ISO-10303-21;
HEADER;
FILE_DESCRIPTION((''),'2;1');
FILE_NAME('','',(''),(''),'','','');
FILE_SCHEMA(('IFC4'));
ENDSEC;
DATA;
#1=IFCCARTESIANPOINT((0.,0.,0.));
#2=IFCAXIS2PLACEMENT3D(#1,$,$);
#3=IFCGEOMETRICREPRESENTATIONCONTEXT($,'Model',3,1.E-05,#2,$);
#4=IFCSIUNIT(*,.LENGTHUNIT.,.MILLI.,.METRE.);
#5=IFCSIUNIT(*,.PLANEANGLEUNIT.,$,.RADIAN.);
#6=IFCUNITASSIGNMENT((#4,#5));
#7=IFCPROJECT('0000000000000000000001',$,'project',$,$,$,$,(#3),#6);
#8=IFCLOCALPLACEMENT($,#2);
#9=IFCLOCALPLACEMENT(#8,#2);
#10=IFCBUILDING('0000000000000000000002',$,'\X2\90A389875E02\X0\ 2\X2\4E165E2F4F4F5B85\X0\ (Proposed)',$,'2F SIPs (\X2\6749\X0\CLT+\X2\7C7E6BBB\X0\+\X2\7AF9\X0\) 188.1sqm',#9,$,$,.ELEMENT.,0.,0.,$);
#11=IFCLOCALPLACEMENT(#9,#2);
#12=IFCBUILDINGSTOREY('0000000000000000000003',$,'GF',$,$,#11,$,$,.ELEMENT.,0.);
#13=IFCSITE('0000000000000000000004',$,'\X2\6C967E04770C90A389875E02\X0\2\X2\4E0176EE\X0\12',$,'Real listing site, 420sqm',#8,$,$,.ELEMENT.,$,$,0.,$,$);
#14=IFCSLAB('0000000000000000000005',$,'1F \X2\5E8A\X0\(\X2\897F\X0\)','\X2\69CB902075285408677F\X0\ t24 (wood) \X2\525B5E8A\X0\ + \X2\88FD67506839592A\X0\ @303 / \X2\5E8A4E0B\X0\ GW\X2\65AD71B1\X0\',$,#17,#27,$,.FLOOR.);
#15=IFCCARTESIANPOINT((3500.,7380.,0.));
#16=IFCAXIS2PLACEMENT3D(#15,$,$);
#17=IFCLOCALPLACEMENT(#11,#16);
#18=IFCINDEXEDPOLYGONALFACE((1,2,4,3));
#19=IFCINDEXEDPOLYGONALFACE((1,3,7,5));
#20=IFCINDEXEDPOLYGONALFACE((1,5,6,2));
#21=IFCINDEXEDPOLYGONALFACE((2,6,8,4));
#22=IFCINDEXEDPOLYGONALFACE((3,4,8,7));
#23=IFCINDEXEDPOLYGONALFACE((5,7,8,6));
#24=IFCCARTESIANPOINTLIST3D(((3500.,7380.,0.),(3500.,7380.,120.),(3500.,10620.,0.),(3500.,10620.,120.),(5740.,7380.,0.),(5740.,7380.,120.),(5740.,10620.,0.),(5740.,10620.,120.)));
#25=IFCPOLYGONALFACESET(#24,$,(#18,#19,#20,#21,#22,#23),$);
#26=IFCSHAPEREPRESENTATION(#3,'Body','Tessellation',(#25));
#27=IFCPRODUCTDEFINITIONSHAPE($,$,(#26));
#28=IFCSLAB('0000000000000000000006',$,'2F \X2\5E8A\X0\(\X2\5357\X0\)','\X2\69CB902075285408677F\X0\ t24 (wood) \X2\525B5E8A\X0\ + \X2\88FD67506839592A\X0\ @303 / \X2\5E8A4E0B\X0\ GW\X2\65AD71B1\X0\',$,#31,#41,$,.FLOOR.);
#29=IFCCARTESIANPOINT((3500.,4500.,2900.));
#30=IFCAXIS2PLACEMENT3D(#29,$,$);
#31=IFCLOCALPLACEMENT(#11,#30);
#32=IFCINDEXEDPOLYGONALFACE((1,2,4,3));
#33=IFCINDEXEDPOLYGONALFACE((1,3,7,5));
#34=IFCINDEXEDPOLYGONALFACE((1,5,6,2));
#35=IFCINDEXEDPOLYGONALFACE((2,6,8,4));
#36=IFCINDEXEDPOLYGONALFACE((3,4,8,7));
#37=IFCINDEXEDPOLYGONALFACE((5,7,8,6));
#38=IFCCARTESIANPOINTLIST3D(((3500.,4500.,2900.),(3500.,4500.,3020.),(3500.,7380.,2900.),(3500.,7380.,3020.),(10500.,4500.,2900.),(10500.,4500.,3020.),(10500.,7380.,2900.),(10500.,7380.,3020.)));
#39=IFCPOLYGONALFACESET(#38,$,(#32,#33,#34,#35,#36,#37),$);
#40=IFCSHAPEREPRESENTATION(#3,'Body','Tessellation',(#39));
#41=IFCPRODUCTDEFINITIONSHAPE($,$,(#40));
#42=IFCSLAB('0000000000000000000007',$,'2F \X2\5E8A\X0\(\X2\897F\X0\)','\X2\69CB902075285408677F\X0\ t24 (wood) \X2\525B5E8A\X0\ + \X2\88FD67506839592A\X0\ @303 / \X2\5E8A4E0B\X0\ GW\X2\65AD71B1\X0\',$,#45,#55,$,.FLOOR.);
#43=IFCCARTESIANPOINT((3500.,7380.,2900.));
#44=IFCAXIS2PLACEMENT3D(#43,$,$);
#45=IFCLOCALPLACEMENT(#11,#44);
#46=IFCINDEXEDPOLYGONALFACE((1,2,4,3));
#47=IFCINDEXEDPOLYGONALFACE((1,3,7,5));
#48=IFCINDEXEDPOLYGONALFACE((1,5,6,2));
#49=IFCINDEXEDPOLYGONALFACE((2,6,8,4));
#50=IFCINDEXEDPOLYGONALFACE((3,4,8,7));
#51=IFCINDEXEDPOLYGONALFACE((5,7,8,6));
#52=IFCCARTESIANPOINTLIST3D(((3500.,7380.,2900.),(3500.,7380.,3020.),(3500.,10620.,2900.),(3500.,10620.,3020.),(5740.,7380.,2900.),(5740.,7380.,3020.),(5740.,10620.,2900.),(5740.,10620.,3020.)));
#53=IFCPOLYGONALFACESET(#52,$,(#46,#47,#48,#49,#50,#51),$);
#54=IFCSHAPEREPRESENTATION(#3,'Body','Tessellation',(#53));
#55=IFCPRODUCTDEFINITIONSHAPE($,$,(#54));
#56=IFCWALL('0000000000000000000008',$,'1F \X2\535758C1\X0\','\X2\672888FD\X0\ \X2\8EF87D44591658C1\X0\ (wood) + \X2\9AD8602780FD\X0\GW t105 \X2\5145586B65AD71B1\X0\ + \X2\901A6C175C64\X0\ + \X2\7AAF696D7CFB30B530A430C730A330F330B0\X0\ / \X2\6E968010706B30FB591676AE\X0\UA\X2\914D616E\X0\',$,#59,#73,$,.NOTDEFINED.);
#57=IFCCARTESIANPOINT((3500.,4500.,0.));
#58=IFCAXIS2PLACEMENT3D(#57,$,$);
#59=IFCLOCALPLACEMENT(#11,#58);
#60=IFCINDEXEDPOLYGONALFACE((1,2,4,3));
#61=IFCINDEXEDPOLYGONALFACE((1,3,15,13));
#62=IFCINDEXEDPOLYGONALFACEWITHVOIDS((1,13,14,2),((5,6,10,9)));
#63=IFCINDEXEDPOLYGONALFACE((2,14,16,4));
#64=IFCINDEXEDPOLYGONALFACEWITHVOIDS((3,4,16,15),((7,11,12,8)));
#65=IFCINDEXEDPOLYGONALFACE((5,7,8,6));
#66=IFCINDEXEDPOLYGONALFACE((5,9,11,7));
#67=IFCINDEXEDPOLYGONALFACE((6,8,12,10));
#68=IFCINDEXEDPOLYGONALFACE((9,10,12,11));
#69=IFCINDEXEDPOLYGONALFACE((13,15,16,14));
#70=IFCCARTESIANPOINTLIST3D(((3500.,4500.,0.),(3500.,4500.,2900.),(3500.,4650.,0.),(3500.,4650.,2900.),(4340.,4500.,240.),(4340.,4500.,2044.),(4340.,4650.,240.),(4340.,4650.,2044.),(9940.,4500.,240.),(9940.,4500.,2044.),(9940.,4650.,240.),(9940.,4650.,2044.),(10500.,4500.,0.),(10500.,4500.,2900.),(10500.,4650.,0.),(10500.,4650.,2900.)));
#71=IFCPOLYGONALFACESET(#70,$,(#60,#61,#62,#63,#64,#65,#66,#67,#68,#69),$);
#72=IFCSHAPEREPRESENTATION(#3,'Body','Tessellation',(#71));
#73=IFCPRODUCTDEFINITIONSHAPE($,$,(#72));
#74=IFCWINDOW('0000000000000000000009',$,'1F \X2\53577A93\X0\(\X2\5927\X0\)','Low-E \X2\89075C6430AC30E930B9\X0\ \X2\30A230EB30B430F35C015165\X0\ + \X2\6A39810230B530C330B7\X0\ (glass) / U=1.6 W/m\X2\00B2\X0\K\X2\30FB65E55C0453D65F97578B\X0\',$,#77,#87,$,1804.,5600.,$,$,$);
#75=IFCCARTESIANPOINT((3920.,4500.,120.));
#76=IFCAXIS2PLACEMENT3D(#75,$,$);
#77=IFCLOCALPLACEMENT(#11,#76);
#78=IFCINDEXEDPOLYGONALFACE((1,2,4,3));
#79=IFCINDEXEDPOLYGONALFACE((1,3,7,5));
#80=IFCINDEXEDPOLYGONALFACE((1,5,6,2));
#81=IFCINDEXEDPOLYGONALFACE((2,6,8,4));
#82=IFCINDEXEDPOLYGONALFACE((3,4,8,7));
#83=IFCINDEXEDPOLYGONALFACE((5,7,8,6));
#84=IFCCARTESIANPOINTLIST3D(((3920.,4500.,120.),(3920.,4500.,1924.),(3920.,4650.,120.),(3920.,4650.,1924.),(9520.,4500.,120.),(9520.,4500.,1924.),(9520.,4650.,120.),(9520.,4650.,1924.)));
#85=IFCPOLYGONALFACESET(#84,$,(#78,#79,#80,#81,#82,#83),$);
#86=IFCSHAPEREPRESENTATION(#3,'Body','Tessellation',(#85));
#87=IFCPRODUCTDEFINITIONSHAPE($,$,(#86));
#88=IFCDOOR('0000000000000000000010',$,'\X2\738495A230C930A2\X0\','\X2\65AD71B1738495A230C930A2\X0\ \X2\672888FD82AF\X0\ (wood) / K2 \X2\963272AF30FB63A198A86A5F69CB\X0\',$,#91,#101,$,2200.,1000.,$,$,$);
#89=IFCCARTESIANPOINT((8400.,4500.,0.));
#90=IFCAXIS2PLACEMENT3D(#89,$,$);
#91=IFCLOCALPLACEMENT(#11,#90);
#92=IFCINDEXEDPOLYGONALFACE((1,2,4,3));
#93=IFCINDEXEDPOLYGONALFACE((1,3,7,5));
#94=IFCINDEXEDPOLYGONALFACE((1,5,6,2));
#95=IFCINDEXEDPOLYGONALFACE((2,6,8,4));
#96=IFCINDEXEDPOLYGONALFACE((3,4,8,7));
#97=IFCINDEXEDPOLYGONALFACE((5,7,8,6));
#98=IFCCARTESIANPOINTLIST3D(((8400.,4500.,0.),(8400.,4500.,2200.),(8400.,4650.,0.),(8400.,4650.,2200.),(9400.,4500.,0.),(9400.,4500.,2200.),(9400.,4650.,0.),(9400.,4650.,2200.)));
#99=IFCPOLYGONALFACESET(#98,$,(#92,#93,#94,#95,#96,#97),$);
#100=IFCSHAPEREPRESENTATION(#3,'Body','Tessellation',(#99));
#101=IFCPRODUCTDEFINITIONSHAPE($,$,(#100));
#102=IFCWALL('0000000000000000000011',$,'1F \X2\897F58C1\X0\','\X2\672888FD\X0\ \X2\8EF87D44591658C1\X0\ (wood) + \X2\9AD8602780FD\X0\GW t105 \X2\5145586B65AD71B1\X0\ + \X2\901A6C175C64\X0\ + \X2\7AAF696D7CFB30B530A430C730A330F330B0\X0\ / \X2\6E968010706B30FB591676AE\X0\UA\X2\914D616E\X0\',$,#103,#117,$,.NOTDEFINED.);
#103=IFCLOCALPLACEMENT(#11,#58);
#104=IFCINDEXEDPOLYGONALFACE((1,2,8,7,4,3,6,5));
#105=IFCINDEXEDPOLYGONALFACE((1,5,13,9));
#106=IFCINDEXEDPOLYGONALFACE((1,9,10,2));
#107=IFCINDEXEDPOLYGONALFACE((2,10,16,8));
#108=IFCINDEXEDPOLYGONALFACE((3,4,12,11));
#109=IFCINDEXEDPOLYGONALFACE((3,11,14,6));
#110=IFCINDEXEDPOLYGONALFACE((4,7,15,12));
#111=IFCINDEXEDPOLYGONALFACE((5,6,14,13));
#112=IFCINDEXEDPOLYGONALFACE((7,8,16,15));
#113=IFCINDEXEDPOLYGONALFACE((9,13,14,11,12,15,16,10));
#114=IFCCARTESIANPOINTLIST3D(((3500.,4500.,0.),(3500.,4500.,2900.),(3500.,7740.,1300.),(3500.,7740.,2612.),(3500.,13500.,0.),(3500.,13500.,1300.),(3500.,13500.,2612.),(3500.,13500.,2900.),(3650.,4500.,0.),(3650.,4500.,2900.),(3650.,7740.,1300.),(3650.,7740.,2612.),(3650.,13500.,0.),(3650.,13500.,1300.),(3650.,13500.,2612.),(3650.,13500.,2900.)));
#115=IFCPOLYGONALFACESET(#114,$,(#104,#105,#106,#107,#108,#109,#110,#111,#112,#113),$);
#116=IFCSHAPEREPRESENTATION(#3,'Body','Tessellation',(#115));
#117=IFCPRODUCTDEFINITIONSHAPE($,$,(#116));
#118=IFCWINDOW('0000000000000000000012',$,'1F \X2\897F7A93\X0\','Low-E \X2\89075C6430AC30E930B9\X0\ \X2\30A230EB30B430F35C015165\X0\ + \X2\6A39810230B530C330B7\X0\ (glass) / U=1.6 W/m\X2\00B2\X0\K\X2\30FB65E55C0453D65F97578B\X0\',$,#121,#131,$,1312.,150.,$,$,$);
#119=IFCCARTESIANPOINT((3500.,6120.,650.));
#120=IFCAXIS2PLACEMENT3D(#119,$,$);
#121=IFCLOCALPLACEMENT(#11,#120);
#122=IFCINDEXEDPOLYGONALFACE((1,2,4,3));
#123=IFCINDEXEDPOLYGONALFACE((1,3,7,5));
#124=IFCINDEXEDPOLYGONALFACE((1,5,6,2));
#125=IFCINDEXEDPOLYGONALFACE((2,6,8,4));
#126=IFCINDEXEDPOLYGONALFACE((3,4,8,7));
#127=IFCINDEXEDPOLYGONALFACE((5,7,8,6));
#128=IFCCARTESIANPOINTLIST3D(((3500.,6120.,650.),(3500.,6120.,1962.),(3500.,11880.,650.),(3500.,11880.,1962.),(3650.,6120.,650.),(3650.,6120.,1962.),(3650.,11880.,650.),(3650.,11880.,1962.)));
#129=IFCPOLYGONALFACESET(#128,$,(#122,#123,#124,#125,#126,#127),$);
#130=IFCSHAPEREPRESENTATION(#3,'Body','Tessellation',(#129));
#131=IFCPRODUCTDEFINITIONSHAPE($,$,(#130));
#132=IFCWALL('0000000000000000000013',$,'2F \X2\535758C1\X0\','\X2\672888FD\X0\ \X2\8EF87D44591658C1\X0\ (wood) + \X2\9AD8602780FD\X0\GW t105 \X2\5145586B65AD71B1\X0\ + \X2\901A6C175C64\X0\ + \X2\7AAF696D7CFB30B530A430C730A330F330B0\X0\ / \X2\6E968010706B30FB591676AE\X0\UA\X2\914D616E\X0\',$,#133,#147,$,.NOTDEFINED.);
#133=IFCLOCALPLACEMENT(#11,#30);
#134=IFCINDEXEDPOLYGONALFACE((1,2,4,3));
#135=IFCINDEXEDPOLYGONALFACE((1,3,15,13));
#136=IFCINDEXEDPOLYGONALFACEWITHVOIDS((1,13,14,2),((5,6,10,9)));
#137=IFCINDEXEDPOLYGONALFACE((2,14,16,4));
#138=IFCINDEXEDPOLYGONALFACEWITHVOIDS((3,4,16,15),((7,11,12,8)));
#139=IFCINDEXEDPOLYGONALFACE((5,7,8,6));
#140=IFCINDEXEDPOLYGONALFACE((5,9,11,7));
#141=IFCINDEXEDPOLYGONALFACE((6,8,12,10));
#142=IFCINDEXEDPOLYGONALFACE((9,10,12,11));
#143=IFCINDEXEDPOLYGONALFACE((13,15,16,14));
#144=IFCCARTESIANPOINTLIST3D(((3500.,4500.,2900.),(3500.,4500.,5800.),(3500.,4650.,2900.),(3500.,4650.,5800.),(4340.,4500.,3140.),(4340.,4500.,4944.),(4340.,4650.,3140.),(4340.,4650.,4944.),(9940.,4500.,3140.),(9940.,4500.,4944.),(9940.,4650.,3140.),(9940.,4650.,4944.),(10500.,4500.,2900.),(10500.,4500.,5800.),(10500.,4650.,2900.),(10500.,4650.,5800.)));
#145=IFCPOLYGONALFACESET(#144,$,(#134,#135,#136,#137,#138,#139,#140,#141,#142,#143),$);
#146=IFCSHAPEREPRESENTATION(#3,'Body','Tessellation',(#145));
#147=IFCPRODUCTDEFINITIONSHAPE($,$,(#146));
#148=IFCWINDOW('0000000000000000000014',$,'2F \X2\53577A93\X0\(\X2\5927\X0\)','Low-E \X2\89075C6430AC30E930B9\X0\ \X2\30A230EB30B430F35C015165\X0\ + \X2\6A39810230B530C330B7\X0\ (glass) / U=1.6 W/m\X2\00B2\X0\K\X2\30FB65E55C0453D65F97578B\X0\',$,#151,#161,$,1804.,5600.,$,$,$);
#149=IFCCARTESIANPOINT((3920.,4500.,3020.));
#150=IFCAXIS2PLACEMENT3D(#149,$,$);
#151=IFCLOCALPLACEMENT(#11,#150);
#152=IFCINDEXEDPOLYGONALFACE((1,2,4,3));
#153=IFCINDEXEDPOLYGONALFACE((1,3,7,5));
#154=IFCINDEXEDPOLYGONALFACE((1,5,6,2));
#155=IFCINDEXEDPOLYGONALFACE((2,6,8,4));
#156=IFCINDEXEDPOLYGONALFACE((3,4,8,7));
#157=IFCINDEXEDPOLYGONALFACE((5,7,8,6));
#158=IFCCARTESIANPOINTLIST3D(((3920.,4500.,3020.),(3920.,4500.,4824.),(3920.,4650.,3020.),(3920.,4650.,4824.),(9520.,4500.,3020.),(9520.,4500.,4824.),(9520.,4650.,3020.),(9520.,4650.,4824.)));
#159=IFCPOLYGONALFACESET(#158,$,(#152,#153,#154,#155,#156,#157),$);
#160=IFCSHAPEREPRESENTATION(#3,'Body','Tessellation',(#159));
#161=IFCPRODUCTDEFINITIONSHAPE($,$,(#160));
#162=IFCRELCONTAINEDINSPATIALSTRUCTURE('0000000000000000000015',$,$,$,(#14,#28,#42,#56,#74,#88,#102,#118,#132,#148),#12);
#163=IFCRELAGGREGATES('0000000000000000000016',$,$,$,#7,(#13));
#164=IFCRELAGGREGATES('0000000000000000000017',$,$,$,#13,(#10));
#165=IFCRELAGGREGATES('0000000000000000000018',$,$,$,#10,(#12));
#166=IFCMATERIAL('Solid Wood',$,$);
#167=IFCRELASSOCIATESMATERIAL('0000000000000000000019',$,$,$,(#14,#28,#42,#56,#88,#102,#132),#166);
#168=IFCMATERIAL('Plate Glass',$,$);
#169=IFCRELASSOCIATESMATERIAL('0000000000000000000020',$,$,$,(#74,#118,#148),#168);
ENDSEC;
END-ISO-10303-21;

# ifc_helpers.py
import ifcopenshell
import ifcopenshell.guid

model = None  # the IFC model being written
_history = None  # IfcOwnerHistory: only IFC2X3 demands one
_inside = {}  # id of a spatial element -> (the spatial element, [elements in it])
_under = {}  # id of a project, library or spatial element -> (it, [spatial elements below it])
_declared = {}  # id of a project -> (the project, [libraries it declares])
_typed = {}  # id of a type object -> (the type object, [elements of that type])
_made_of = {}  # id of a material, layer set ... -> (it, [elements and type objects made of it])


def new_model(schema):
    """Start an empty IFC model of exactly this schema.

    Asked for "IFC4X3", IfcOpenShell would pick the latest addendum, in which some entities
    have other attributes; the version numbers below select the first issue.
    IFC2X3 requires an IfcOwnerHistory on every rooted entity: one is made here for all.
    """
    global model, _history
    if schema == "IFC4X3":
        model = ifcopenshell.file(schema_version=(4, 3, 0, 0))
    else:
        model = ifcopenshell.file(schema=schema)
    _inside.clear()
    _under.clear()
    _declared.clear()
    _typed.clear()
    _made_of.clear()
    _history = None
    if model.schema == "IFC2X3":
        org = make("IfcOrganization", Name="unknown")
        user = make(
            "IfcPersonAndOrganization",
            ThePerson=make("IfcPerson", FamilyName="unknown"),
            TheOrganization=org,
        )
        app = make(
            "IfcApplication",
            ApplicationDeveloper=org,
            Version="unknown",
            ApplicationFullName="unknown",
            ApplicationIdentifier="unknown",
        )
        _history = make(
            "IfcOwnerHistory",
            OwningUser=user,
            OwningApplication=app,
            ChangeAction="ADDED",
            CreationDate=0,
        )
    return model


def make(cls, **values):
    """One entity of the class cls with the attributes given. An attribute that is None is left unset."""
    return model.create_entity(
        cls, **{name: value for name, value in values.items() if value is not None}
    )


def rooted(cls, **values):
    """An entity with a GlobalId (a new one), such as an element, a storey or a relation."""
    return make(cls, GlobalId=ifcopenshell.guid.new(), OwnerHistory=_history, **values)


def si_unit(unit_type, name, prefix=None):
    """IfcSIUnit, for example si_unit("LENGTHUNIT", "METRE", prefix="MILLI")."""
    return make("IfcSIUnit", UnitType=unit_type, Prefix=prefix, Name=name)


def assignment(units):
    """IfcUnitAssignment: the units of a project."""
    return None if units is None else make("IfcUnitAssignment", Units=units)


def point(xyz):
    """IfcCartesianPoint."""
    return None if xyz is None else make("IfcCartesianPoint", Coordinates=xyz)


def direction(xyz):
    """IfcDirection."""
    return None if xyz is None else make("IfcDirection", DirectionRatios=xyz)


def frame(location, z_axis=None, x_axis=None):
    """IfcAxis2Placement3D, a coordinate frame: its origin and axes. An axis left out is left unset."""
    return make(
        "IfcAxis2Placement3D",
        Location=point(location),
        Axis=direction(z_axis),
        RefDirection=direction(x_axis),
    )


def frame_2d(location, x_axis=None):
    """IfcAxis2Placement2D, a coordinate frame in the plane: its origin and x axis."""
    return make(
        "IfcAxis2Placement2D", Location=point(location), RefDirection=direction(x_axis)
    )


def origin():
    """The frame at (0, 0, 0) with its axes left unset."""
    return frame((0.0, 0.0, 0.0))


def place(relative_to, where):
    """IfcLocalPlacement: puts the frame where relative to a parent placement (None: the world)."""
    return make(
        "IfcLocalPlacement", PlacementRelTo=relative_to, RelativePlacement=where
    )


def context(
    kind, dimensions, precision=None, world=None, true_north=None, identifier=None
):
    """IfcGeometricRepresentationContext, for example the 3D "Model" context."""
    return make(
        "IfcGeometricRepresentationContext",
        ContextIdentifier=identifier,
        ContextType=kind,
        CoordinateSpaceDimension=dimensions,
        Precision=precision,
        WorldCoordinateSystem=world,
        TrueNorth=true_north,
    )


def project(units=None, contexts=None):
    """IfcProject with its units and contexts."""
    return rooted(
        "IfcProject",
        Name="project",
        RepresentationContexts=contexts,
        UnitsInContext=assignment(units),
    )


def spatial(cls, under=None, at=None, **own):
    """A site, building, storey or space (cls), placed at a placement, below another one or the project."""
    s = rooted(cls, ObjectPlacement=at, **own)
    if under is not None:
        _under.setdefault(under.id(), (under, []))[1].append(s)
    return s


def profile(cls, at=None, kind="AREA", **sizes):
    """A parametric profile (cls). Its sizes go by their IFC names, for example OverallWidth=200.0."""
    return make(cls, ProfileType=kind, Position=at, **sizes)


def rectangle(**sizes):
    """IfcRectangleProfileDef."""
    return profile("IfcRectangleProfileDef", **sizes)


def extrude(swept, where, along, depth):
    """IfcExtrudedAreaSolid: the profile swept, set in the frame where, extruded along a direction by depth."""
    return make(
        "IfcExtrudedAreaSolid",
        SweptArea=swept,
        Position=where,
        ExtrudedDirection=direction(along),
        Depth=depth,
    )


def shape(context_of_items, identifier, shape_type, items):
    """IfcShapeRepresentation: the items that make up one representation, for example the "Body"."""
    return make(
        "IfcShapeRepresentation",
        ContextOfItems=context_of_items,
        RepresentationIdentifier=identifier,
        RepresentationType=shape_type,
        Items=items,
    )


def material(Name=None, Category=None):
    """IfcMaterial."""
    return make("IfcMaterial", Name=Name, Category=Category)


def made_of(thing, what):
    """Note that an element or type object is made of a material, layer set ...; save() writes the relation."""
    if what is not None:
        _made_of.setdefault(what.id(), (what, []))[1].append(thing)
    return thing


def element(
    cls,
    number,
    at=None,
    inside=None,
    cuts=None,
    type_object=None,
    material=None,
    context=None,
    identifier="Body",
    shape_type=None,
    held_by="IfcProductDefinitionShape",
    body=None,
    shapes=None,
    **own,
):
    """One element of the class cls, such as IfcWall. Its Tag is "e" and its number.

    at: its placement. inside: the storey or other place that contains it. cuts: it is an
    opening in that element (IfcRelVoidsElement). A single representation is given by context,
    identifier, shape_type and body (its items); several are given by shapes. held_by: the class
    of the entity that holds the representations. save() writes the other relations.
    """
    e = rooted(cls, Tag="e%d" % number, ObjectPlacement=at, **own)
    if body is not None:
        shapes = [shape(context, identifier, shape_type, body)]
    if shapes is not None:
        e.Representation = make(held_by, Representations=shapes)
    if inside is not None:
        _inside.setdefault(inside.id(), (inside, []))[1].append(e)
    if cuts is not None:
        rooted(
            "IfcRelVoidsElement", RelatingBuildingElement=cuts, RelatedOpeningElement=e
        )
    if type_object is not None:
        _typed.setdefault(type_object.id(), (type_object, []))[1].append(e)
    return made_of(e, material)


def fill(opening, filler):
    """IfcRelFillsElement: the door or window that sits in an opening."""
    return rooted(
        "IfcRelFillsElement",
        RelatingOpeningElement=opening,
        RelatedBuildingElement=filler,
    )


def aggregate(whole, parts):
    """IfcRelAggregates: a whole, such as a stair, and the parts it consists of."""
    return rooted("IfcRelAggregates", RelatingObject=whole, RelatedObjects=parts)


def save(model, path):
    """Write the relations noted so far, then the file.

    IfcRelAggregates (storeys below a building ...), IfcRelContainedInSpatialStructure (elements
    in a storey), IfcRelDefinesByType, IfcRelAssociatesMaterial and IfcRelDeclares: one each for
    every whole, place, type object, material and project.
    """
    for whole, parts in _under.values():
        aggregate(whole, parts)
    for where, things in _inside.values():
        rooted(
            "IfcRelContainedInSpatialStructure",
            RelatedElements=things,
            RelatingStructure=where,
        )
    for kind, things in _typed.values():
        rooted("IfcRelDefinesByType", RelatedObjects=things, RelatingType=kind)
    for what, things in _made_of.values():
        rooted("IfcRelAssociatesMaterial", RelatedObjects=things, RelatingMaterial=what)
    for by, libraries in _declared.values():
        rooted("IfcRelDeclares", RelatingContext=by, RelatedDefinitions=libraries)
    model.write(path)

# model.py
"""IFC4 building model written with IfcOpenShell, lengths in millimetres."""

from ifc_helpers import new_model, si_unit, frame, frame_2d, origin, place, context, project, spatial, rectangle, extrude, material, element, fill, save


model = new_model("IFC4")

# Units and contexts
model_context = context("Model", 3, precision=1e-05, world=origin())
ifc_project = project(units=[si_unit("LENGTHUNIT", "METRE", prefix="MILLI"), si_unit("PLANEANGLEUNIT", "RADIAN")], contexts=[model_context])

# Site, building, storey
site_placement = place(None, origin())
site = spatial("IfcSite", under=ifc_project, at=site_placement, Name="沖縄県那覇市2丁目12", ObjectType="Real listing site, 420sqm", CompositionType="ELEMENT", RefElevation=0.0)
building_placement = place(site_placement, origin())
building = spatial("IfcBuilding", under=site, at=building_placement, Name="那覇市 2世帯住宅 (Proposed)", ObjectType="2F SIPs (杉CLT+籾殻+竹) 188.1sqm", CompositionType="ELEMENT", ElevationOfRefHeight=0.0, ElevationOfTerrain=0.0)
storey_placement = place(building_placement, origin())
storey = spatial("IfcBuildingStorey", under=building, at=storey_placement, Name="GF", CompositionType="ELEMENT", Elevation=0.0)

# Slabs
ifc_material_1 = material(Name="Solid Wood")
slab_1_placement = place(storey_placement, frame((3500.0, 7380.0, 0.0)))
element("IfcSlab", 1, at=slab_1_placement, inside=storey, material=ifc_material_1, Name="1F 床(西)", Description="構造用合板 t24 (wood) 剛床 + 製材根太 @303 / 床下 GW断熱", PredefinedType="FLOOR", context=model_context, shape_type="SweptSolid", body=[
    extrude(rectangle(XDim=2240.0, YDim=3240.0, at=frame_2d((1120.0, 1620.0))), frame((3500.0, 7380.0, 0.0)), (0.0, 0.0, 1.0), 120.0),
])
slab_2_placement = place(storey_placement, frame((3500.0, 4500.0, 2900.0)))
element("IfcSlab", 2, at=slab_2_placement, inside=storey, material=ifc_material_1, Name="2F 床(南)", Description="構造用合板 t24 (wood) 剛床 + 製材根太 @303 / 床下 GW断熱", PredefinedType="FLOOR", context=model_context, shape_type="SweptSolid", body=[
    extrude(rectangle(XDim=7000.0, YDim=2880.0, at=frame_2d((3500.0, 1440.0))), frame((3500.0, 4500.0, 2900.0)), (0.0, 0.0, 1.0), 120.0),
])
slab_3_placement = place(storey_placement, frame((3500.0, 7380.0, 2900.0)))
element("IfcSlab", 3, at=slab_3_placement, inside=storey, material=ifc_material_1, Name="2F 床(西)", Description="構造用合板 t24 (wood) 剛床 + 製材根太 @303 / 床下 GW断熱", PredefinedType="FLOOR", context=model_context, shape_type="SweptSolid", body=[
    extrude(rectangle(XDim=2240.0, YDim=3240.0, at=frame_2d((1120.0, 1620.0))), frame((3500.0, 7380.0, 2900.0)), (0.0, 0.0, 1.0), 120.0),
])

# Wall, openings, window, door
wall_1_placement = place(storey_placement, frame((3500.0, 4500.0, 0.0)))
wall_1 = element("IfcWall", 4, at=wall_1_placement, inside=storey, material=ifc_material_1, Name="1F 南壁", Description="木製 軸組外壁 (wood) + 高性能GW t105 充填断熱 + 通気層 + 窯業系サイディング / 準耐火・外皮UA配慮", PredefinedType="NOTDEFINED", context=model_context, shape_type="SweptSolid", body=[
    extrude(rectangle(XDim=7000.0, YDim=150.0, at=frame_2d((3500.0, 75.0))), frame((3500.0, 4500.0, 0.0)), (0.0, 0.0, 1.0), 2900.0),
])
opening_1_placement = place(storey_placement, frame((3920.0, 4500.0, 120.0)))
opening_1 = element("IfcOpeningElement", 5, at=opening_1_placement, cuts=wall_1, PredefinedType="NOTDEFINED", context=model_context, shape_type="SweptSolid", body=[
    extrude(rectangle(XDim=5600.0, YDim=150.0, at=frame_2d((2800.0, 75.0))), frame((3920.0, 4500.0, 120.0)), (0.0, 0.0, 1.0), 1804.0),
])
opening_2_placement = place(storey_placement, frame((8400.0, 4500.0, 0.0)))
opening_2 = element("IfcOpeningElement", 6, at=opening_2_placement, cuts=wall_1, PredefinedType="NOTDEFINED", context=model_context, shape_type="SweptSolid", body=[
    extrude(rectangle(XDim=1000.0, YDim=150.0, at=frame_2d((500.0, 75.0))), frame((8400.0, 4500.0, 0.0)), (0.0, 0.0, 1.0), 2200.0),
])
ifc_material_2 = material(Name="Plate Glass")
window_1_placement = place(storey_placement, frame((3920.0, 4500.0, 120.0)))
window_1 = element("IfcWindow", 7, at=window_1_placement, inside=storey, material=ifc_material_2, Name="1F 南窓(大)", Description="Low-E 複層ガラス アルゴン封入 + 樹脂サッシ (glass) / U=1.6 W/m²K・日射取得型", OverallHeight=1804.0, OverallWidth=5600.0, context=model_context, shape_type="SweptSolid", body=[
    extrude(rectangle(XDim=5600.0, YDim=150.0, at=frame_2d((2800.0, 75.0))), frame((3920.0, 4500.0, 120.0)), (0.0, 0.0, 1.0), 1804.0),
])
fill(opening_1, window_1)
door_placement = place(storey_placement, frame((8400.0, 4500.0, 0.0)))
door = element("IfcDoor", 8, at=door_placement, inside=storey, material=ifc_material_1, Name="玄関ドア", Description="断熱玄関ドア 木製芯 (wood) / K2 防犯・採風機構", OverallHeight=2200.0, OverallWidth=1000.0, context=model_context, shape_type="SweptSolid", body=[
    extrude(rectangle(XDim=1000.0, YDim=150.0, at=frame_2d((500.0, 75.0))), frame((8400.0, 4500.0, 0.0)), (0.0, 0.0, 1.0), 2200.0),
])
fill(opening_2, door)

# Walls, openings, windows
wall_2_placement = place(storey_placement, frame((3500.0, 4500.0, 0.0)))
wall_2 = element("IfcWall", 9, at=wall_2_placement, inside=storey, material=ifc_material_1, Name="1F 西壁", Description="木製 軸組外壁 (wood) + 高性能GW t105 充填断熱 + 通気層 + 窯業系サイディング / 準耐火・外皮UA配慮", PredefinedType="NOTDEFINED", context=model_context, shape_type="SweptSolid", body=[
    extrude(rectangle(XDim=150.0, YDim=9000.0, at=frame_2d((75.0, 4500.0))), frame((3500.0, 4500.0, 0.0)), (0.0, 0.0, 1.0), 2900.0),
])
opening_3_placement = place(storey_placement, frame((3500.0, 6120.0, 650.0)))
opening_3 = element("IfcOpeningElement", 10, at=opening_3_placement, cuts=wall_2, PredefinedType="NOTDEFINED", context=model_context, shape_type="SweptSolid", body=[
    extrude(rectangle(XDim=150.0, YDim=5760.0, at=frame_2d((75.0, 2880.0))), frame((3500.0, 6120.0, 650.0)), (0.0, 0.0, 1.0), 1312.0),
])
window_2_placement = place(storey_placement, frame((3500.0, 6120.0, 650.0)))
window_2 = element("IfcWindow", 11, at=window_2_placement, inside=storey, material=ifc_material_2, Name="1F 西窓", Description="Low-E 複層ガラス アルゴン封入 + 樹脂サッシ (glass) / U=1.6 W/m²K・日射取得型", OverallHeight=1312.0, OverallWidth=150.0, context=model_context, shape_type="SweptSolid", body=[
    extrude(rectangle(XDim=150.0, YDim=5760.0, at=frame_2d((75.0, 2880.0))), frame((3500.0, 6120.0, 650.0)), (0.0, 0.0, 1.0), 1312.0),
])
fill(opening_3, window_2)
wall_3_placement = place(storey_placement, frame((3500.0, 4500.0, 2900.0)))
wall_3 = element("IfcWall", 12, at=wall_3_placement, inside=storey, material=ifc_material_1, Name="2F 南壁", Description="木製 軸組外壁 (wood) + 高性能GW t105 充填断熱 + 通気層 + 窯業系サイディング / 準耐火・外皮UA配慮", PredefinedType="NOTDEFINED", context=model_context, shape_type="SweptSolid", body=[
    extrude(rectangle(XDim=7000.0, YDim=150.0, at=frame_2d((3500.0, 75.0))), frame((3500.0, 4500.0, 2900.0)), (0.0, 0.0, 1.0), 2900.0),
])
opening_4_placement = place(storey_placement, frame((3920.0, 4500.0, 3020.0)))
opening_4 = element("IfcOpeningElement", 13, at=opening_4_placement, cuts=wall_3, PredefinedType="NOTDEFINED", context=model_context, shape_type="SweptSolid", body=[
    extrude(rectangle(XDim=5600.0, YDim=150.0, at=frame_2d((2800.0, 75.0))), frame((3920.0, 4500.0, 3020.0)), (0.0, 0.0, 1.0), 1804.0),
])
window_3_placement = place(storey_placement, frame((3920.0, 4500.0, 3020.0)))
window_3 = element("IfcWindow", 14, at=window_3_placement, inside=storey, material=ifc_material_2, Name="2F 南窓(大)", Description="Low-E 複層ガラス アルゴン封入 + 樹脂サッシ (glass) / U=1.6 W/m²K・日射取得型", OverallHeight=1804.0, OverallWidth=5600.0, context=model_context, shape_type="SweptSolid", body=[
    extrude(rectangle(XDim=5600.0, YDim=150.0, at=frame_2d((2800.0, 75.0))), frame((3920.0, 4500.0, 3020.0)), (0.0, 0.0, 1.0), 1804.0),
])
fill(opening_4, window_3)

save(model, "model.ifc")
